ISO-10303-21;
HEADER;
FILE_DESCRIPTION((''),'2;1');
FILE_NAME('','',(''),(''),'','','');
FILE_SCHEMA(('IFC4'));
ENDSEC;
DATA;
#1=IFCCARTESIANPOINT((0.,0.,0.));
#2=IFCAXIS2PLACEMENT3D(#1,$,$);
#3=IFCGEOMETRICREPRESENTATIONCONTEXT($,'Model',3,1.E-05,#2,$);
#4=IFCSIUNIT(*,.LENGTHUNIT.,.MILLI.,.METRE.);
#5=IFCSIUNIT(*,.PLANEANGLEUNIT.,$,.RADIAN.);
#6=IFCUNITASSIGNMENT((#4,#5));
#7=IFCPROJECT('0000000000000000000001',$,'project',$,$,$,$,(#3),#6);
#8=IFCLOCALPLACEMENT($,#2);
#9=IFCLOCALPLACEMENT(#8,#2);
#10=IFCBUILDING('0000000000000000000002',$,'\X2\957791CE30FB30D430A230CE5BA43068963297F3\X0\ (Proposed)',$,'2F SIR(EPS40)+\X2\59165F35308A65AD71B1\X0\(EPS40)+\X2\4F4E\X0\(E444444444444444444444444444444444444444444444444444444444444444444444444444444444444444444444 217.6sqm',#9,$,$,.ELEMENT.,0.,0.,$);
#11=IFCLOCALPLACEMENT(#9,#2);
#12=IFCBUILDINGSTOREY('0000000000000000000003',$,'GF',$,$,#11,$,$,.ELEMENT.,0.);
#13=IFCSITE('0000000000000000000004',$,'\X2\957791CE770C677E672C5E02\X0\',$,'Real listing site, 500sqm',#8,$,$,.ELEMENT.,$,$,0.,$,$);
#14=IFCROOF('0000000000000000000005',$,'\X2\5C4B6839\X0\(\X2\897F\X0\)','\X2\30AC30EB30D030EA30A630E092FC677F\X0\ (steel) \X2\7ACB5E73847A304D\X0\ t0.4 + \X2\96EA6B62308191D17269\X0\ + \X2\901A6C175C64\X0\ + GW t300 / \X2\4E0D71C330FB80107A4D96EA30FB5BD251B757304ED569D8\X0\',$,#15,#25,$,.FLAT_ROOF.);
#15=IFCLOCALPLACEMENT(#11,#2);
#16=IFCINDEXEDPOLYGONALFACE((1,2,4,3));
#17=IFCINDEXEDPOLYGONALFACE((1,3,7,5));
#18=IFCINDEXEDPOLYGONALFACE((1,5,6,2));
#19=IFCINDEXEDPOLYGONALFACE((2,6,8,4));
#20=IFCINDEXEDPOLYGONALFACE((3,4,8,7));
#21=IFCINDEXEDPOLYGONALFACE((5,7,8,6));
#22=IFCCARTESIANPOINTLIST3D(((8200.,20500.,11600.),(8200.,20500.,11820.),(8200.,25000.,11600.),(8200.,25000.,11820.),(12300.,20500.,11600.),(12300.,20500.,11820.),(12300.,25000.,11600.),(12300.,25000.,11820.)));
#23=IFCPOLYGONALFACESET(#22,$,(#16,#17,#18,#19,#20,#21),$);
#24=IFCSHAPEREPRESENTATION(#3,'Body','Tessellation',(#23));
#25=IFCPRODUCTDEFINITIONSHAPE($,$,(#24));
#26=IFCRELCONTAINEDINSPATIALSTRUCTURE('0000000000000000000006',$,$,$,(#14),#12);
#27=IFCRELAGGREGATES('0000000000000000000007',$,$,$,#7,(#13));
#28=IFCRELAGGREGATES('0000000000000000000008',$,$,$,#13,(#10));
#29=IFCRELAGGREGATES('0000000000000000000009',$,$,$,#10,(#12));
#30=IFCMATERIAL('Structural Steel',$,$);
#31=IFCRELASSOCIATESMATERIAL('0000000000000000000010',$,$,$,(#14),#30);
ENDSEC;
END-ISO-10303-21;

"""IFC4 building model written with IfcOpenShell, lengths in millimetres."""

from ifc_helpers import new_model, si_unit, frame, frame_2d, origin, place, context, project, spatial, rectangle, extrude, material, element, save


model = new_model("IFC4")

# Units and contexts
model_context = context("Model", 3, precision=1e-05, world=origin())
ifc_project = project(units=[si_unit("LENGTHUNIT", "METRE", prefix="MILLI"), si_unit("PLANEANGLEUNIT", "RADIAN")], contexts=[model_context])

# Site, building, storey
site_placement = place(None, origin())
site = spatial("IfcSite", under=ifc_project, at=site_placement, Name="長野県松本市", ObjectType="Real listing site, 500sqm", CompositionType="ELEMENT", RefElevation=0.0)
building_placement = place(site_placement, origin())
building = spatial("IfcBuilding", under=site, at=building_placement, Name="長野・ピアノ室と防音 (Proposed)", ObjectType="2F SIR(EPS40)+外張り断熱(EPS40)+低(E444444444444444444444444444444444444444444444444444444444444444444444444444444444444444444444 217.6sqm", CompositionType="ELEMENT", ElevationOfRefHeight=0.0, ElevationOfTerrain=0.0)
storey_placement = place(building_placement, origin())
storey = spatial("IfcBuildingStorey", under=building, at=storey_placement, Name="GF", CompositionType="ELEMENT", Elevation=0.0)

# Roof
ifc_material_1 = material(Name="Structural Steel")
for number, where, name in (
    (1, (4100.0, 10250.0, 5800.0), "屋根(西)"),
):
    element("IfcRoof", number, at=place(storey_placement, frame(where)), inside=storey, material=ifc_material_1, Name=name, Description="ガルバリウム鋼板 (steel) 立平葺き t0.4 + 雪止め金物 + 通気層 + GW t300 / 不燃・耐積雪・寒冷地仕様", PredefinedType="FLAT_ROOF", context=model_context, shape_type="SweptSolid", body=[
        extrude(rectangle(XDim=4100.0, YDim=4500.0, at=frame_2d((2050.0, 2250.0))), frame((4100.0, 10250.0, 5800.0)), (0.0, 0.0, 1.0), 220.0),
    ])

save(model, "model.ifc")
